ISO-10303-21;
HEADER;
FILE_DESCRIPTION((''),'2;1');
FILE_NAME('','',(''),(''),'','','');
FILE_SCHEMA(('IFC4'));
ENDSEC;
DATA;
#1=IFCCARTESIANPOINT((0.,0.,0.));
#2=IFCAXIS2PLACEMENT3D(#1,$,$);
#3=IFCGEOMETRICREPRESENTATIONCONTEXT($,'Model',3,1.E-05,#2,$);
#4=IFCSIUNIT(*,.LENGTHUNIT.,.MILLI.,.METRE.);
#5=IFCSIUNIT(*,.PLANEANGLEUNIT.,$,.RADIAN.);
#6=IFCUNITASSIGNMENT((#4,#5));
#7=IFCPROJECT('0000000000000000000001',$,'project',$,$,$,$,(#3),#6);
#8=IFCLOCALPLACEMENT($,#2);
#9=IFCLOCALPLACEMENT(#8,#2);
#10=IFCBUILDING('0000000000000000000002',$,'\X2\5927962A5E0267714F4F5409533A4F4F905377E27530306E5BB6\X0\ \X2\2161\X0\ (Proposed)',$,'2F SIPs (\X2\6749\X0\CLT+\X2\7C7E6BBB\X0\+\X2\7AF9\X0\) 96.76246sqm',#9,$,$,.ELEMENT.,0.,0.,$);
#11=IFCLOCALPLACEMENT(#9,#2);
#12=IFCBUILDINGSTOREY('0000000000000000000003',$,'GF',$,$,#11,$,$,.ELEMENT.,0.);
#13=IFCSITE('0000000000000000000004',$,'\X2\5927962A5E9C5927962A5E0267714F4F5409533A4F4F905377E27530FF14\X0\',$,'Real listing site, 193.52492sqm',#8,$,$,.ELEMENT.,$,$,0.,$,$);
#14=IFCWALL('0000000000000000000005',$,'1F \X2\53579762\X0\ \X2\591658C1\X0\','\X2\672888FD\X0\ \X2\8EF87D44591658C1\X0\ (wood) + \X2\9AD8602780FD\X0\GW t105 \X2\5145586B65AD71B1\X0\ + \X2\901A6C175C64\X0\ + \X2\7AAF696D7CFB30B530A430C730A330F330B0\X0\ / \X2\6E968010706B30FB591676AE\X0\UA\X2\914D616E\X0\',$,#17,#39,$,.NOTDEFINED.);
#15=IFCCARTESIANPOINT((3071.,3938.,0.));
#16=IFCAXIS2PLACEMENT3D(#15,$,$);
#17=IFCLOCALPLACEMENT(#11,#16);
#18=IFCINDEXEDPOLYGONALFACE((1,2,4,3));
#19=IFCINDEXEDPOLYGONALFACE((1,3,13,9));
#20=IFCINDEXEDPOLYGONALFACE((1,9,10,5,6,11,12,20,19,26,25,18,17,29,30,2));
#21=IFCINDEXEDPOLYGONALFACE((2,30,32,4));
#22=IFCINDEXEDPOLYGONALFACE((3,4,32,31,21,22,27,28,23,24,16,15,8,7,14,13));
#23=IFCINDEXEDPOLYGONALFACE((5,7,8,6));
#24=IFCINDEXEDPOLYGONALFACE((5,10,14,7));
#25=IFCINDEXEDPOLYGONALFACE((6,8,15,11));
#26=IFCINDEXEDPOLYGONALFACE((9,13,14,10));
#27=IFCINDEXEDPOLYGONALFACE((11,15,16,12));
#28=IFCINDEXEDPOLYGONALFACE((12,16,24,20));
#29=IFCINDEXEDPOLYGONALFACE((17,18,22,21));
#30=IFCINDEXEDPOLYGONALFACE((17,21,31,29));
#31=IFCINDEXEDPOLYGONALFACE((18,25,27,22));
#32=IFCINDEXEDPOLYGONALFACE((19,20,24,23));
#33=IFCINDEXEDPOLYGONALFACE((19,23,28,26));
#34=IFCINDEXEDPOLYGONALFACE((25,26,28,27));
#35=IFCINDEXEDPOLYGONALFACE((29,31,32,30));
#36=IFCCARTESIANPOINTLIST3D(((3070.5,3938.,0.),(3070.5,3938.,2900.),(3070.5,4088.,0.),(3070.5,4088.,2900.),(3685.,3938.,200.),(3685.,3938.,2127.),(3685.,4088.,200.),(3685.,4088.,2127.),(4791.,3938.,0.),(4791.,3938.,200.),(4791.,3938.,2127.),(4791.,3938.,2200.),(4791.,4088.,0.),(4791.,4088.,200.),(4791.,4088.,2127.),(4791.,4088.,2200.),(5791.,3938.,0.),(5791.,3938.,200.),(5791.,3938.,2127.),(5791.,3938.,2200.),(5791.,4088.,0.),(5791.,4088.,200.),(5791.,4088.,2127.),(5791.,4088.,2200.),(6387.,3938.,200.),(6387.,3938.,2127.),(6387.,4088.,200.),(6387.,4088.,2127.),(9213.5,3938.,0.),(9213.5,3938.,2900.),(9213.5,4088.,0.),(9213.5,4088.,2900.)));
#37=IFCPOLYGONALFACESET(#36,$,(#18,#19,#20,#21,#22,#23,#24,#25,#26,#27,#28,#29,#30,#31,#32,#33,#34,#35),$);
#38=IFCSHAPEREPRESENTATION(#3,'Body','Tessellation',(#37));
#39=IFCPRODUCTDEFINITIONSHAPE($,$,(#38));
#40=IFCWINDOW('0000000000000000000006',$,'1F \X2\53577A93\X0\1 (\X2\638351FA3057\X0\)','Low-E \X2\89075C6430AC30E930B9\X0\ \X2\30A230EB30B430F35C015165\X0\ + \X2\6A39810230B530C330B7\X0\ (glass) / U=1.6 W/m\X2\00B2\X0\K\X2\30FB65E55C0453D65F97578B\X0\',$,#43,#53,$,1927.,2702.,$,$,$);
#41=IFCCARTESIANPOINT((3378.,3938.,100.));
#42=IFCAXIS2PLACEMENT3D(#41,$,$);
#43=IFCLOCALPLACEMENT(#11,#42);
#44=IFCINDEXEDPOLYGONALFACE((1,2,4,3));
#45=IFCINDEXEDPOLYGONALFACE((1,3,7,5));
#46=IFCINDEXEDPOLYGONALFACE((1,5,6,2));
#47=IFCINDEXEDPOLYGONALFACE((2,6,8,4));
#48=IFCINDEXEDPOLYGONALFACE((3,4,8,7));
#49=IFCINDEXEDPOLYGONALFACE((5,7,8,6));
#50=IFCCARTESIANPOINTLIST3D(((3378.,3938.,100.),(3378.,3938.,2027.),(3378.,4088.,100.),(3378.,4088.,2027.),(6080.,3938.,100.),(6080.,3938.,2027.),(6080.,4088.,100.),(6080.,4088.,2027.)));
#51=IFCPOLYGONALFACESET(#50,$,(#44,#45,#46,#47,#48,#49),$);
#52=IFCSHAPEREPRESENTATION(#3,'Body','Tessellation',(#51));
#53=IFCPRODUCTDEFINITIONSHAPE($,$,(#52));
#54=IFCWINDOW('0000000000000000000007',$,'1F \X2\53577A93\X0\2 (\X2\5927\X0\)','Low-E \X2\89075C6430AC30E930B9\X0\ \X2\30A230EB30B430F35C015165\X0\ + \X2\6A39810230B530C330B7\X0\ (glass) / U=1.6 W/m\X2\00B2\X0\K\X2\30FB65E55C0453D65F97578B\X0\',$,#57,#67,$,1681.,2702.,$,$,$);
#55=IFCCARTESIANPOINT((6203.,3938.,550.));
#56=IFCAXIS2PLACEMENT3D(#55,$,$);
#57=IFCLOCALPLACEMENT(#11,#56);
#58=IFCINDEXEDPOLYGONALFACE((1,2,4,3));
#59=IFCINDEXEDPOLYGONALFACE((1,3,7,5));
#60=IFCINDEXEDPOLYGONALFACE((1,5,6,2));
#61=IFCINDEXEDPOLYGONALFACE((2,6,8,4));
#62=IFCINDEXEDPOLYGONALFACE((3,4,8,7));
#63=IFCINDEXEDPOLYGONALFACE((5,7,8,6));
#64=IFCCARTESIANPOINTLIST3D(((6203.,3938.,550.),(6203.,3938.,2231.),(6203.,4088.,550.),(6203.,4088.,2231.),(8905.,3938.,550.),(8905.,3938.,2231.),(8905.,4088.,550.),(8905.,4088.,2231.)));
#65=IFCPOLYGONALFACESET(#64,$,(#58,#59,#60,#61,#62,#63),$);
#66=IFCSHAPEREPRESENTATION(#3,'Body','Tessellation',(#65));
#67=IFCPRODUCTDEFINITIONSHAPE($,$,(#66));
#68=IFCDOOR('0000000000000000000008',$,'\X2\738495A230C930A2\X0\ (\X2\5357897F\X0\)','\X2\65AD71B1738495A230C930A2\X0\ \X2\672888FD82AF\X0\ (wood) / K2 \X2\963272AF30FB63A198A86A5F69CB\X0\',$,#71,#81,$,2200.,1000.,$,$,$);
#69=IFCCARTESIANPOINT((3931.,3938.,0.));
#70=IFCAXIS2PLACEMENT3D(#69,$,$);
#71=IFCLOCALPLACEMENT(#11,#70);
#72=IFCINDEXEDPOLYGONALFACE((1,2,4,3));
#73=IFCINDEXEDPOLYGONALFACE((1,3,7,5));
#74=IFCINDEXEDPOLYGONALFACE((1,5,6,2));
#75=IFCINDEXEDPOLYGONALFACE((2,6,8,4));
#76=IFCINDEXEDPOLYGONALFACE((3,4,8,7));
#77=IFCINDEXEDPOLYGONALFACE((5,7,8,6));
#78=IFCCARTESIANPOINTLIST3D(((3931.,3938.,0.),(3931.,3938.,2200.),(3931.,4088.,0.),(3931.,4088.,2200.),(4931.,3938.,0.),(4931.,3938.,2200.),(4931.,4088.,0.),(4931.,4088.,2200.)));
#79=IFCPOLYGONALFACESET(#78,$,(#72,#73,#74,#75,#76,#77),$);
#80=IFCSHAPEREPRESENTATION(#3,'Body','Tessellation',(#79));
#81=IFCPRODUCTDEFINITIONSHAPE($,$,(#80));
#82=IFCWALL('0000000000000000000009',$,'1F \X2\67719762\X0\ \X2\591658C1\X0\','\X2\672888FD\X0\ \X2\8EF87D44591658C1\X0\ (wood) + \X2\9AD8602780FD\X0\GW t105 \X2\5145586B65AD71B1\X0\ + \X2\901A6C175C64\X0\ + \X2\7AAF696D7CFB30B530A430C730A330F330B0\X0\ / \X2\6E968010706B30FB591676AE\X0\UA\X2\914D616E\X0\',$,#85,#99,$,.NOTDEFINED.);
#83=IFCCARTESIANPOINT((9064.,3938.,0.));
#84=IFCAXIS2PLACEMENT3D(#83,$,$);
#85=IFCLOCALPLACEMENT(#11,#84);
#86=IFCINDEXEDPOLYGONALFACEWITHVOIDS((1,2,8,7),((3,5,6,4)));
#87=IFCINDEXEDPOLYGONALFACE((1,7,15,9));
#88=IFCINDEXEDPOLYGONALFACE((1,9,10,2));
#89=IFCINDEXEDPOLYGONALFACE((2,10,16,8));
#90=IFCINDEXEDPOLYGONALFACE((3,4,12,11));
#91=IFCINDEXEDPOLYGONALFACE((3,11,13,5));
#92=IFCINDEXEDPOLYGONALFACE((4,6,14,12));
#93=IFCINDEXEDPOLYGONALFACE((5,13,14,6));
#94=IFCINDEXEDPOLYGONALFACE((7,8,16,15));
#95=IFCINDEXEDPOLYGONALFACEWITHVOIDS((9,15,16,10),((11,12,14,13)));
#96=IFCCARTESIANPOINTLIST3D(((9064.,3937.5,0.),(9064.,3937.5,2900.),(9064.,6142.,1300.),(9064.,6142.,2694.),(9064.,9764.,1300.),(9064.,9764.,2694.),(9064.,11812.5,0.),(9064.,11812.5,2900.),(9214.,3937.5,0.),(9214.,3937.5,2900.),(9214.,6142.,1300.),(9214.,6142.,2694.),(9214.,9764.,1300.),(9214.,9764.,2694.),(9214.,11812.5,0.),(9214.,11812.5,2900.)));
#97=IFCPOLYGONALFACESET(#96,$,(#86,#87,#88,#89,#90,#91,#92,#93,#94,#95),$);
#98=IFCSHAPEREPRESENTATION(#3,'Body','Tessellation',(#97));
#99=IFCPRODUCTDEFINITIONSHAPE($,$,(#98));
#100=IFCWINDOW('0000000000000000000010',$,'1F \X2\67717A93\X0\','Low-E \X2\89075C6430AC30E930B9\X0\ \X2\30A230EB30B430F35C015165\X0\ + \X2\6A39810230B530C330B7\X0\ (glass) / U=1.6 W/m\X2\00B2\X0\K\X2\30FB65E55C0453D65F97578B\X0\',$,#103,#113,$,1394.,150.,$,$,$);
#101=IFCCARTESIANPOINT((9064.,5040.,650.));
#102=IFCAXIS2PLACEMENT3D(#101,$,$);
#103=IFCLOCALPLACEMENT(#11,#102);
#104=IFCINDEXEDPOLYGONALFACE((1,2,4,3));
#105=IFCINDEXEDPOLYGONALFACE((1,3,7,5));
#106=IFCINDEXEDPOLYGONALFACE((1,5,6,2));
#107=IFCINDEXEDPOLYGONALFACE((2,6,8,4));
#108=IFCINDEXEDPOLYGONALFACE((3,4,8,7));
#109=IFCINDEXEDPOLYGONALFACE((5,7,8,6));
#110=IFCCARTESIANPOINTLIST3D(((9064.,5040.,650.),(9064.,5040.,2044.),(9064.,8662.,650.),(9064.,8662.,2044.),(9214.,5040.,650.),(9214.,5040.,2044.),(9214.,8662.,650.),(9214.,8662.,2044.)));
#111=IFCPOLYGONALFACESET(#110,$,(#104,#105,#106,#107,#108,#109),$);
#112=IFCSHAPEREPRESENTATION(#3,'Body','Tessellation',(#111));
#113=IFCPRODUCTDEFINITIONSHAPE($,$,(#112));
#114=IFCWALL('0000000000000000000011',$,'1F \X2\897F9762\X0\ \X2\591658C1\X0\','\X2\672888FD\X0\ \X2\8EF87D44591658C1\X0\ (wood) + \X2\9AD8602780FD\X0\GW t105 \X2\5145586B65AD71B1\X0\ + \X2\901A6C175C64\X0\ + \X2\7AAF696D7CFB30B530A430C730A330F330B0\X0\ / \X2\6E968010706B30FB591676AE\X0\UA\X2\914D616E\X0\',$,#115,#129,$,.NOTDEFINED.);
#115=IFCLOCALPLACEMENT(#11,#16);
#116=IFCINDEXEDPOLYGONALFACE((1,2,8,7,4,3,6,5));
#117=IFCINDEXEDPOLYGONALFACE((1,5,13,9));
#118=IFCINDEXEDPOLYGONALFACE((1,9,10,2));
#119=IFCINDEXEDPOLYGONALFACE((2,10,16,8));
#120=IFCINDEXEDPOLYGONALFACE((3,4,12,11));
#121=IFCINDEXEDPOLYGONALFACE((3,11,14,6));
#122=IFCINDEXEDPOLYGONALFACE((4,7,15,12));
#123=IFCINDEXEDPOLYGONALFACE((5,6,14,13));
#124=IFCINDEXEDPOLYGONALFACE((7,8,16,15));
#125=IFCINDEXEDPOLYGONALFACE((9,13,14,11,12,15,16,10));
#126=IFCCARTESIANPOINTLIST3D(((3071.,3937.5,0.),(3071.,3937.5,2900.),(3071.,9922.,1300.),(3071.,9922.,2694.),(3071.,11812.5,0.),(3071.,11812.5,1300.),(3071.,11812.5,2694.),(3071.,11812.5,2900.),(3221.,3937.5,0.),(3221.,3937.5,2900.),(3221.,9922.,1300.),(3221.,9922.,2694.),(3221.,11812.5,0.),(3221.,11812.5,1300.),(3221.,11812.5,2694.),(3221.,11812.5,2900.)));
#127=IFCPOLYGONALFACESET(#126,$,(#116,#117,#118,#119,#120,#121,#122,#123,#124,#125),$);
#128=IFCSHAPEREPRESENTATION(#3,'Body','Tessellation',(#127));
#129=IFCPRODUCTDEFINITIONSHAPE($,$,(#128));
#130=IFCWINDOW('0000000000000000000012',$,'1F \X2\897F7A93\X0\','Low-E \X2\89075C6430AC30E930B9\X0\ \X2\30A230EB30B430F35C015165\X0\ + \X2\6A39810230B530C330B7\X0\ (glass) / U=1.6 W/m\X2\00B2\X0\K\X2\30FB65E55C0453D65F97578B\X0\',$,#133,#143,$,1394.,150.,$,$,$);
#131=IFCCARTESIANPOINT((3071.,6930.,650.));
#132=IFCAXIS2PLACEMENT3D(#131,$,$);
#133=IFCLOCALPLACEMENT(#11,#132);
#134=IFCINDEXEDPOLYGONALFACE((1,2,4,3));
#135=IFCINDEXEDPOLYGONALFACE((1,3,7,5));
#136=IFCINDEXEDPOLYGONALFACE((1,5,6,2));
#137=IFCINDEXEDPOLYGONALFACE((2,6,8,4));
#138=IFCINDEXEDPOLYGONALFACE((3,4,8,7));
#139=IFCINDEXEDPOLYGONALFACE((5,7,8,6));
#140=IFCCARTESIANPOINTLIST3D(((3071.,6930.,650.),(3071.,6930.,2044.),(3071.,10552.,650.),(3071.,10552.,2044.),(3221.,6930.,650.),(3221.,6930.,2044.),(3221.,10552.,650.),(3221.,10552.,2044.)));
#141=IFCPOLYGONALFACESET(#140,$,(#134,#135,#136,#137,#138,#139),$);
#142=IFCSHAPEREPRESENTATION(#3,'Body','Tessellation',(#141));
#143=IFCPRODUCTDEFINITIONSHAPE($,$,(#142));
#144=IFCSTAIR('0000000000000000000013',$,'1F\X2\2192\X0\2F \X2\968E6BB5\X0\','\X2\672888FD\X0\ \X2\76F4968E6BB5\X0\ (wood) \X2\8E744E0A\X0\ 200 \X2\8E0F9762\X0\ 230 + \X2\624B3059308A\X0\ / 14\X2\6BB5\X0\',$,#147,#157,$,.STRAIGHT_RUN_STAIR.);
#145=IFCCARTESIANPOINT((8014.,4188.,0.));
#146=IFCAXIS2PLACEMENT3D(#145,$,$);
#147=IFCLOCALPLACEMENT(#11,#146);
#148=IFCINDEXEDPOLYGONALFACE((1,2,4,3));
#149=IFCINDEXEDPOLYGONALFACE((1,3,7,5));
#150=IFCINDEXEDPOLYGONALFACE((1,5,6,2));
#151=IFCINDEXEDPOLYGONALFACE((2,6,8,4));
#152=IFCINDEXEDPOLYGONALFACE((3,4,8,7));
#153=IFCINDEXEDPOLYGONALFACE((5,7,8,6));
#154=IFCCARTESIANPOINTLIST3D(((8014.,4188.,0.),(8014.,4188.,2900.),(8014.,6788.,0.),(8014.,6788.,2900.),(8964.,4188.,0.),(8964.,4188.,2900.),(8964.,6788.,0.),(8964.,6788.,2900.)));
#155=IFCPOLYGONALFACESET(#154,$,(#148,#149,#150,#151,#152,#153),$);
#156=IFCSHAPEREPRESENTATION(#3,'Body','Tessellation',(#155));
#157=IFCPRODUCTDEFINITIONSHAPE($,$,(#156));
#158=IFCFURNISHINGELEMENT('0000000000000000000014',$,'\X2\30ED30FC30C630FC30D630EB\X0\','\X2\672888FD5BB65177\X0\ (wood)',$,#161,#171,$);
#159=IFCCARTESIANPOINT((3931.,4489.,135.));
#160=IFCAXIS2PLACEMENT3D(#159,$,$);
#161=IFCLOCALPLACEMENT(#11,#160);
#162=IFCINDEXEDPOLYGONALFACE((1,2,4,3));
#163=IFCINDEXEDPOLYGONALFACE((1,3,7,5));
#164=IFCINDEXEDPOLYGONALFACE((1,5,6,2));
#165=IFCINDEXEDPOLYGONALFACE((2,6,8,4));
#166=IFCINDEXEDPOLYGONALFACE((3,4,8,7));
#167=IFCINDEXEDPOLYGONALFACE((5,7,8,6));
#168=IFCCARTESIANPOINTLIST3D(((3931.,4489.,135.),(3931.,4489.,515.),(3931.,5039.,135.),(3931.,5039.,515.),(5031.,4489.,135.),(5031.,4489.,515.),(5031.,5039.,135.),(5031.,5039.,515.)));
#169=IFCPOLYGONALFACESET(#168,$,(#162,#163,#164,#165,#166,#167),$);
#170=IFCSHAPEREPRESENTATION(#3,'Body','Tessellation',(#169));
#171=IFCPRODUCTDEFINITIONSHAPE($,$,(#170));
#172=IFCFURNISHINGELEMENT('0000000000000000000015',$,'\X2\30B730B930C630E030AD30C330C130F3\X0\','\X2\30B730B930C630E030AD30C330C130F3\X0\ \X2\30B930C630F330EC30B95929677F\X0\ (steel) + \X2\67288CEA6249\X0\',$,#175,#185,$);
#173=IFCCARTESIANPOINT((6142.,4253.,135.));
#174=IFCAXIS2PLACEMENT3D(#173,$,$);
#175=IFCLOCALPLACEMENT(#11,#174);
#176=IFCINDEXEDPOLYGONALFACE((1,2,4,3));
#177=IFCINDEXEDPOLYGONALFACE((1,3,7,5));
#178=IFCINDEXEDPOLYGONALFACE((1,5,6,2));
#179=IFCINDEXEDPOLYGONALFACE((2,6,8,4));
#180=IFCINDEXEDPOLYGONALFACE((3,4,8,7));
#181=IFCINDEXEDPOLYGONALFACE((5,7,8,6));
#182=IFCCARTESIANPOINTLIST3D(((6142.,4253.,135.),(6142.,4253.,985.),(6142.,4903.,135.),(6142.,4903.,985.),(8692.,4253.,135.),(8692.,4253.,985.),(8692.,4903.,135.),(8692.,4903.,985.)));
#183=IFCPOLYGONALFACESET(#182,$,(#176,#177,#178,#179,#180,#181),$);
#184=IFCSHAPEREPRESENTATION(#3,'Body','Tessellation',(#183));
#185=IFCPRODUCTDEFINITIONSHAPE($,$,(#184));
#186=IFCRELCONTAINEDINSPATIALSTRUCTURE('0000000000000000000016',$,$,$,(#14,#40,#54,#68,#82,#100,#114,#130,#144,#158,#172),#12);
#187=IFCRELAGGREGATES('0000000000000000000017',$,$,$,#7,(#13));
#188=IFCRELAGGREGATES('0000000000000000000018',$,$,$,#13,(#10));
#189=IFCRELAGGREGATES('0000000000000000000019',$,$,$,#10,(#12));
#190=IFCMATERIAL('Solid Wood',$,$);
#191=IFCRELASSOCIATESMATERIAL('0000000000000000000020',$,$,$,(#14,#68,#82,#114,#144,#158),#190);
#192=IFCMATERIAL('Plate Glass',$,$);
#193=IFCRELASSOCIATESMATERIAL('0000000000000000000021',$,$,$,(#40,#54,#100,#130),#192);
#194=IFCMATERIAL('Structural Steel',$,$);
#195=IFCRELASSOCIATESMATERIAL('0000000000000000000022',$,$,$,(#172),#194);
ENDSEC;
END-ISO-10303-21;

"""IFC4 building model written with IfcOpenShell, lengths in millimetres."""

from ifc_helpers import new_model, si_unit, frame, frame_2d, origin, place, context, project, spatial, rectangle, extrude, material, element, fill, save


model = new_model("IFC4")

# Units and contexts
model_context = context("Model", 3, precision=1e-05, world=origin())
ifc_project = project(units=[si_unit("LENGTHUNIT", "METRE", prefix="MILLI"), si_unit("PLANEANGLEUNIT", "RADIAN")], contexts=[model_context])

# Site, building, storey
site_placement = place(None, origin())
site = spatial("IfcSite", under=ifc_project, at=site_placement, Name="大阪府大阪市東住吉区住道矢田４", ObjectType="Real listing site, 193.52492sqm", CompositionType="ELEMENT", RefElevation=0.0)
building_placement = place(site_placement, origin())
building = spatial("IfcBuilding", under=site, at=building_placement, Name="大阪市東住吉区住道矢田の家 Ⅱ (Proposed)", ObjectType="2F SIPs (杉CLT+籾殻+竹) 96.76246sqm", CompositionType="ELEMENT", ElevationOfRefHeight=0.0, ElevationOfTerrain=0.0)
storey_placement = place(building_placement, origin())
storey = spatial("IfcBuildingStorey", under=building, at=storey_placement, Name="GF", CompositionType="ELEMENT", Elevation=0.0)

# Shared definitions
ifc_material_1 = material(Name="Solid Wood")

# Wall, openings, windows, door
wall_1_placement = place(storey_placement, frame((3071.0, 3938.0, 0.0)))
wall_1 = element("IfcWall", 1, at=wall_1_placement, inside=storey, material=ifc_material_1, Name="1F 南面 外壁", Description="木製 軸組外壁 (wood) + 高性能GW t105 充填断熱 + 通気層 + 窯業系サイディング / 準耐火・外皮UA配慮", PredefinedType="NOTDEFINED", context=model_context, shape_type="SweptSolid", body=[
    extrude(rectangle(XDim=6143.0, YDim=150.0, at=frame_2d((3071.0, 75.0))), frame((3071.0, 3938.0, 0.0)), (0.0, 0.0, 1.0), 2900.0),
])
opening_1_placement = place(storey_placement, frame((3378.0, 3938.0, 100.0)))
opening_1 = element("IfcOpeningElement", 2, at=opening_1_placement, cuts=wall_1, PredefinedType="NOTDEFINED", context=model_context, shape_type="SweptSolid", body=[
    extrude(rectangle(XDim=2702.0, YDim=150.0, at=frame_2d((1351.0, 75.0))), frame((3378.0, 3938.0, 100.0)), (0.0, 0.0, 1.0), 1927.0),
])
opening_2_placement = place(storey_placement, frame((6203.0, 3938.0, 550.0)))
opening_2 = element("IfcOpeningElement", 3, at=opening_2_placement, cuts=wall_1, PredefinedType="NOTDEFINED", context=model_context, shape_type="SweptSolid", body=[
    extrude(rectangle(XDim=2702.0, YDim=150.0, at=frame_2d((1351.0, 75.0))), frame((6203.0, 3938.0, 550.0)), (0.0, 0.0, 1.0), 1681.0),
])
opening_3_placement = place(storey_placement, frame((3931.0, 3938.0, 0.0)))
opening_3 = element("IfcOpeningElement", 4, at=opening_3_placement, cuts=wall_1, PredefinedType="NOTDEFINED", context=model_context, shape_type="SweptSolid", body=[
    extrude(rectangle(XDim=1000.0, YDim=150.0, at=frame_2d((500.0, 75.0))), frame((3931.0, 3938.0, 0.0)), (0.0, 0.0, 1.0), 2200.0),
])
ifc_material_2 = material(Name="Plate Glass")
window_1_placement = place(storey_placement, frame((3378.0, 3938.0, 100.0)))
window_1 = element("IfcWindow", 5, at=window_1_placement, inside=storey, material=ifc_material_2, Name="1F 南窓1 (掃出し)", Description="Low-E 複層ガラス アルゴン封入 + 樹脂サッシ (glass) / U=1.6 W/m²K・日射取得型", OverallHeight=1927.0, OverallWidth=2702.0, context=model_context, shape_type="SweptSolid", body=[
    extrude(rectangle(XDim=2702.0, YDim=150.0, at=frame_2d((1351.0, 75.0))), frame((3378.0, 3938.0, 100.0)), (0.0, 0.0, 1.0), 1927.0),
])
fill(opening_1, window_1)
window_2_placement = place(storey_placement, frame((6203.0, 3938.0, 550.0)))
window_2 = element("IfcWindow", 6, at=window_2_placement, inside=storey, material=ifc_material_2, Name="1F 南窓2 (大)", Description="Low-E 複層ガラス アルゴン封入 + 樹脂サッシ (glass) / U=1.6 W/m²K・日射取得型", OverallHeight=1681.0, OverallWidth=2702.0, context=model_context, shape_type="SweptSolid", body=[
    extrude(rectangle(XDim=2702.0, YDim=150.0, at=frame_2d((1351.0, 75.0))), frame((6203.0, 3938.0, 550.0)), (0.0, 0.0, 1.0), 1681.0),
])
fill(opening_2, window_2)
door_placement = place(storey_placement, frame((3931.0, 3938.0, 0.0)))
door = element("IfcDoor", 7, at=door_placement, inside=storey, material=ifc_material_1, Name="玄関ドア (南西)", Description="断熱玄関ドア 木製芯 (wood) / K2 防犯・採風機構", OverallHeight=2200.0, OverallWidth=1000.0, context=model_context, shape_type="SweptSolid", body=[
    extrude(rectangle(XDim=1000.0, YDim=150.0, at=frame_2d((500.0, 75.0))), frame((3931.0, 3938.0, 0.0)), (0.0, 0.0, 1.0), 2200.0),
])
fill(opening_3, door)

# Walls, openings, windows
wall_2_placement = place(storey_placement, frame((9064.0, 3938.0, 0.0)))
wall_2 = element("IfcWall", 8, at=wall_2_placement, inside=storey, material=ifc_material_1, Name="1F 東面 外壁", Description="木製 軸組外壁 (wood) + 高性能GW t105 充填断熱 + 通気層 + 窯業系サイディング / 準耐火・外皮UA配慮", PredefinedType="NOTDEFINED", context=model_context, shape_type="SweptSolid", body=[
    extrude(rectangle(XDim=150.0, YDim=7875.0, at=frame_2d((75.0, 3937.0))), frame((9064.0, 3938.0, 0.0)), (0.0, 0.0, 1.0), 2900.0),
])
opening_4_placement = place(storey_placement, frame((9064.0, 5040.0, 650.0)))
opening_4 = element("IfcOpeningElement", 9, at=opening_4_placement, cuts=wall_2, PredefinedType="NOTDEFINED", context=model_context, shape_type="SweptSolid", body=[
    extrude(rectangle(XDim=150.0, YDim=3622.0, at=frame_2d((75.0, 1811.0))), frame((9064.0, 5040.0, 650.0)), (0.0, 0.0, 1.0), 1394.0),
])
window_3_placement = place(storey_placement, frame((9064.0, 5040.0, 650.0)))
window_3 = element("IfcWindow", 10, at=window_3_placement, inside=storey, material=ifc_material_2, Name="1F 東窓", Description="Low-E 複層ガラス アルゴン封入 + 樹脂サッシ (glass) / U=1.6 W/m²K・日射取得型", OverallHeight=1394.0, OverallWidth=150.0, context=model_context, shape_type="SweptSolid", body=[
    extrude(rectangle(XDim=150.0, YDim=3622.0, at=frame_2d((75.0, 1811.0))), frame((9064.0, 5040.0, 650.0)), (0.0, 0.0, 1.0), 1394.0),
])
fill(opening_4, window_3)
wall_3_placement = place(storey_placement, frame((3071.0, 3938.0, 0.0)))
wall_3 = element("IfcWall", 11, at=wall_3_placement, inside=storey, material=ifc_material_1, Name="1F 西面 外壁", Description="木製 軸組外壁 (wood) + 高性能GW t105 充填断熱 + 通気層 + 窯業系サイディング / 準耐火・外皮UA配慮", PredefinedType="NOTDEFINED", context=model_context, shape_type="SweptSolid", body=[
    extrude(rectangle(XDim=150.0, YDim=7875.0, at=frame_2d((75.0, 3937.0))), frame((3071.0, 3938.0, 0.0)), (0.0, 0.0, 1.0), 2900.0),
])
opening_5_placement = place(storey_placement, frame((3071.0, 6930.0, 650.0)))
opening_5 = element("IfcOpeningElement", 12, at=opening_5_placement, cuts=wall_3, PredefinedType="NOTDEFINED", context=model_context, shape_type="SweptSolid", body=[
    extrude(rectangle(XDim=150.0, YDim=3622.0, at=frame_2d((75.0, 1811.0))), frame((3071.0, 6930.0, 650.0)), (0.0, 0.0, 1.0), 1394.0),
])
window_4_placement = place(storey_placement, frame((3071.0, 6930.0, 650.0)))
window_4 = element("IfcWindow", 13, at=window_4_placement, inside=storey, material=ifc_material_2, Name="1F 西窓", Description="Low-E 複層ガラス アルゴン封入 + 樹脂サッシ (glass) / U=1.6 W/m²K・日射取得型", OverallHeight=1394.0, OverallWidth=150.0, context=model_context, shape_type="SweptSolid", body=[
    extrude(rectangle(XDim=150.0, YDim=3622.0, at=frame_2d((75.0, 1811.0))), frame((3071.0, 6930.0, 650.0)), (0.0, 0.0, 1.0), 1394.0),
])
fill(opening_5, window_4)

# Stair
stair_placement = place(storey_placement, frame((8014.0, 4188.0, 0.0)))
element("IfcStair", 14, at=stair_placement, inside=storey, material=ifc_material_1, Name="1F→2F 階段", Description="木製 直階段 (wood) 蹴上 200 踏面 230 + 手すり / 14段", PredefinedType="STRAIGHT_RUN_STAIR", context=model_context, shape_type="SweptSolid", body=[
    extrude(rectangle(XDim=950.0, YDim=2600.0, at=frame_2d((475.0, 1300.0))), frame((8014.0, 4188.0, 0.0)), (0.0, 0.0, 1.0), 2900.0),
])

# Furnishing elements
furnishing_1_placement = place(storey_placement, frame((3931.0, 4489.0, 135.0)))
element("IfcFurnishingElement", 15, at=furnishing_1_placement, inside=storey, material=ifc_material_1, Name="ローテーブル", Description="木製家具 (wood)", context=model_context, shape_type="SweptSolid", body=[
    extrude(rectangle(XDim=1100.0, YDim=550.0, at=frame_2d((550.0, 275.0))), frame((3931.0, 4489.0, 135.0)), (0.0, 0.0, 1.0), 380.0),
])
ifc_material_3 = material(Name="Structural Steel")
furnishing_2_placement = place(storey_placement, frame((6142.0, 4253.0, 135.0)))
element("IfcFurnishingElement", 16, at=furnishing_2_placement, inside=storey, material=ifc_material_3, Name="システムキッチン", Description="システムキッチン ステンレス天板 (steel) + 木質扉", context=model_context, shape_type="SweptSolid", body=[
    extrude(rectangle(XDim=2550.0, YDim=650.0, at=frame_2d((1275.0, 325.0))), frame((6142.0, 4253.0, 135.0)), (0.0, 0.0, 1.0), 850.0),
])

save(model, "model.ifc")
